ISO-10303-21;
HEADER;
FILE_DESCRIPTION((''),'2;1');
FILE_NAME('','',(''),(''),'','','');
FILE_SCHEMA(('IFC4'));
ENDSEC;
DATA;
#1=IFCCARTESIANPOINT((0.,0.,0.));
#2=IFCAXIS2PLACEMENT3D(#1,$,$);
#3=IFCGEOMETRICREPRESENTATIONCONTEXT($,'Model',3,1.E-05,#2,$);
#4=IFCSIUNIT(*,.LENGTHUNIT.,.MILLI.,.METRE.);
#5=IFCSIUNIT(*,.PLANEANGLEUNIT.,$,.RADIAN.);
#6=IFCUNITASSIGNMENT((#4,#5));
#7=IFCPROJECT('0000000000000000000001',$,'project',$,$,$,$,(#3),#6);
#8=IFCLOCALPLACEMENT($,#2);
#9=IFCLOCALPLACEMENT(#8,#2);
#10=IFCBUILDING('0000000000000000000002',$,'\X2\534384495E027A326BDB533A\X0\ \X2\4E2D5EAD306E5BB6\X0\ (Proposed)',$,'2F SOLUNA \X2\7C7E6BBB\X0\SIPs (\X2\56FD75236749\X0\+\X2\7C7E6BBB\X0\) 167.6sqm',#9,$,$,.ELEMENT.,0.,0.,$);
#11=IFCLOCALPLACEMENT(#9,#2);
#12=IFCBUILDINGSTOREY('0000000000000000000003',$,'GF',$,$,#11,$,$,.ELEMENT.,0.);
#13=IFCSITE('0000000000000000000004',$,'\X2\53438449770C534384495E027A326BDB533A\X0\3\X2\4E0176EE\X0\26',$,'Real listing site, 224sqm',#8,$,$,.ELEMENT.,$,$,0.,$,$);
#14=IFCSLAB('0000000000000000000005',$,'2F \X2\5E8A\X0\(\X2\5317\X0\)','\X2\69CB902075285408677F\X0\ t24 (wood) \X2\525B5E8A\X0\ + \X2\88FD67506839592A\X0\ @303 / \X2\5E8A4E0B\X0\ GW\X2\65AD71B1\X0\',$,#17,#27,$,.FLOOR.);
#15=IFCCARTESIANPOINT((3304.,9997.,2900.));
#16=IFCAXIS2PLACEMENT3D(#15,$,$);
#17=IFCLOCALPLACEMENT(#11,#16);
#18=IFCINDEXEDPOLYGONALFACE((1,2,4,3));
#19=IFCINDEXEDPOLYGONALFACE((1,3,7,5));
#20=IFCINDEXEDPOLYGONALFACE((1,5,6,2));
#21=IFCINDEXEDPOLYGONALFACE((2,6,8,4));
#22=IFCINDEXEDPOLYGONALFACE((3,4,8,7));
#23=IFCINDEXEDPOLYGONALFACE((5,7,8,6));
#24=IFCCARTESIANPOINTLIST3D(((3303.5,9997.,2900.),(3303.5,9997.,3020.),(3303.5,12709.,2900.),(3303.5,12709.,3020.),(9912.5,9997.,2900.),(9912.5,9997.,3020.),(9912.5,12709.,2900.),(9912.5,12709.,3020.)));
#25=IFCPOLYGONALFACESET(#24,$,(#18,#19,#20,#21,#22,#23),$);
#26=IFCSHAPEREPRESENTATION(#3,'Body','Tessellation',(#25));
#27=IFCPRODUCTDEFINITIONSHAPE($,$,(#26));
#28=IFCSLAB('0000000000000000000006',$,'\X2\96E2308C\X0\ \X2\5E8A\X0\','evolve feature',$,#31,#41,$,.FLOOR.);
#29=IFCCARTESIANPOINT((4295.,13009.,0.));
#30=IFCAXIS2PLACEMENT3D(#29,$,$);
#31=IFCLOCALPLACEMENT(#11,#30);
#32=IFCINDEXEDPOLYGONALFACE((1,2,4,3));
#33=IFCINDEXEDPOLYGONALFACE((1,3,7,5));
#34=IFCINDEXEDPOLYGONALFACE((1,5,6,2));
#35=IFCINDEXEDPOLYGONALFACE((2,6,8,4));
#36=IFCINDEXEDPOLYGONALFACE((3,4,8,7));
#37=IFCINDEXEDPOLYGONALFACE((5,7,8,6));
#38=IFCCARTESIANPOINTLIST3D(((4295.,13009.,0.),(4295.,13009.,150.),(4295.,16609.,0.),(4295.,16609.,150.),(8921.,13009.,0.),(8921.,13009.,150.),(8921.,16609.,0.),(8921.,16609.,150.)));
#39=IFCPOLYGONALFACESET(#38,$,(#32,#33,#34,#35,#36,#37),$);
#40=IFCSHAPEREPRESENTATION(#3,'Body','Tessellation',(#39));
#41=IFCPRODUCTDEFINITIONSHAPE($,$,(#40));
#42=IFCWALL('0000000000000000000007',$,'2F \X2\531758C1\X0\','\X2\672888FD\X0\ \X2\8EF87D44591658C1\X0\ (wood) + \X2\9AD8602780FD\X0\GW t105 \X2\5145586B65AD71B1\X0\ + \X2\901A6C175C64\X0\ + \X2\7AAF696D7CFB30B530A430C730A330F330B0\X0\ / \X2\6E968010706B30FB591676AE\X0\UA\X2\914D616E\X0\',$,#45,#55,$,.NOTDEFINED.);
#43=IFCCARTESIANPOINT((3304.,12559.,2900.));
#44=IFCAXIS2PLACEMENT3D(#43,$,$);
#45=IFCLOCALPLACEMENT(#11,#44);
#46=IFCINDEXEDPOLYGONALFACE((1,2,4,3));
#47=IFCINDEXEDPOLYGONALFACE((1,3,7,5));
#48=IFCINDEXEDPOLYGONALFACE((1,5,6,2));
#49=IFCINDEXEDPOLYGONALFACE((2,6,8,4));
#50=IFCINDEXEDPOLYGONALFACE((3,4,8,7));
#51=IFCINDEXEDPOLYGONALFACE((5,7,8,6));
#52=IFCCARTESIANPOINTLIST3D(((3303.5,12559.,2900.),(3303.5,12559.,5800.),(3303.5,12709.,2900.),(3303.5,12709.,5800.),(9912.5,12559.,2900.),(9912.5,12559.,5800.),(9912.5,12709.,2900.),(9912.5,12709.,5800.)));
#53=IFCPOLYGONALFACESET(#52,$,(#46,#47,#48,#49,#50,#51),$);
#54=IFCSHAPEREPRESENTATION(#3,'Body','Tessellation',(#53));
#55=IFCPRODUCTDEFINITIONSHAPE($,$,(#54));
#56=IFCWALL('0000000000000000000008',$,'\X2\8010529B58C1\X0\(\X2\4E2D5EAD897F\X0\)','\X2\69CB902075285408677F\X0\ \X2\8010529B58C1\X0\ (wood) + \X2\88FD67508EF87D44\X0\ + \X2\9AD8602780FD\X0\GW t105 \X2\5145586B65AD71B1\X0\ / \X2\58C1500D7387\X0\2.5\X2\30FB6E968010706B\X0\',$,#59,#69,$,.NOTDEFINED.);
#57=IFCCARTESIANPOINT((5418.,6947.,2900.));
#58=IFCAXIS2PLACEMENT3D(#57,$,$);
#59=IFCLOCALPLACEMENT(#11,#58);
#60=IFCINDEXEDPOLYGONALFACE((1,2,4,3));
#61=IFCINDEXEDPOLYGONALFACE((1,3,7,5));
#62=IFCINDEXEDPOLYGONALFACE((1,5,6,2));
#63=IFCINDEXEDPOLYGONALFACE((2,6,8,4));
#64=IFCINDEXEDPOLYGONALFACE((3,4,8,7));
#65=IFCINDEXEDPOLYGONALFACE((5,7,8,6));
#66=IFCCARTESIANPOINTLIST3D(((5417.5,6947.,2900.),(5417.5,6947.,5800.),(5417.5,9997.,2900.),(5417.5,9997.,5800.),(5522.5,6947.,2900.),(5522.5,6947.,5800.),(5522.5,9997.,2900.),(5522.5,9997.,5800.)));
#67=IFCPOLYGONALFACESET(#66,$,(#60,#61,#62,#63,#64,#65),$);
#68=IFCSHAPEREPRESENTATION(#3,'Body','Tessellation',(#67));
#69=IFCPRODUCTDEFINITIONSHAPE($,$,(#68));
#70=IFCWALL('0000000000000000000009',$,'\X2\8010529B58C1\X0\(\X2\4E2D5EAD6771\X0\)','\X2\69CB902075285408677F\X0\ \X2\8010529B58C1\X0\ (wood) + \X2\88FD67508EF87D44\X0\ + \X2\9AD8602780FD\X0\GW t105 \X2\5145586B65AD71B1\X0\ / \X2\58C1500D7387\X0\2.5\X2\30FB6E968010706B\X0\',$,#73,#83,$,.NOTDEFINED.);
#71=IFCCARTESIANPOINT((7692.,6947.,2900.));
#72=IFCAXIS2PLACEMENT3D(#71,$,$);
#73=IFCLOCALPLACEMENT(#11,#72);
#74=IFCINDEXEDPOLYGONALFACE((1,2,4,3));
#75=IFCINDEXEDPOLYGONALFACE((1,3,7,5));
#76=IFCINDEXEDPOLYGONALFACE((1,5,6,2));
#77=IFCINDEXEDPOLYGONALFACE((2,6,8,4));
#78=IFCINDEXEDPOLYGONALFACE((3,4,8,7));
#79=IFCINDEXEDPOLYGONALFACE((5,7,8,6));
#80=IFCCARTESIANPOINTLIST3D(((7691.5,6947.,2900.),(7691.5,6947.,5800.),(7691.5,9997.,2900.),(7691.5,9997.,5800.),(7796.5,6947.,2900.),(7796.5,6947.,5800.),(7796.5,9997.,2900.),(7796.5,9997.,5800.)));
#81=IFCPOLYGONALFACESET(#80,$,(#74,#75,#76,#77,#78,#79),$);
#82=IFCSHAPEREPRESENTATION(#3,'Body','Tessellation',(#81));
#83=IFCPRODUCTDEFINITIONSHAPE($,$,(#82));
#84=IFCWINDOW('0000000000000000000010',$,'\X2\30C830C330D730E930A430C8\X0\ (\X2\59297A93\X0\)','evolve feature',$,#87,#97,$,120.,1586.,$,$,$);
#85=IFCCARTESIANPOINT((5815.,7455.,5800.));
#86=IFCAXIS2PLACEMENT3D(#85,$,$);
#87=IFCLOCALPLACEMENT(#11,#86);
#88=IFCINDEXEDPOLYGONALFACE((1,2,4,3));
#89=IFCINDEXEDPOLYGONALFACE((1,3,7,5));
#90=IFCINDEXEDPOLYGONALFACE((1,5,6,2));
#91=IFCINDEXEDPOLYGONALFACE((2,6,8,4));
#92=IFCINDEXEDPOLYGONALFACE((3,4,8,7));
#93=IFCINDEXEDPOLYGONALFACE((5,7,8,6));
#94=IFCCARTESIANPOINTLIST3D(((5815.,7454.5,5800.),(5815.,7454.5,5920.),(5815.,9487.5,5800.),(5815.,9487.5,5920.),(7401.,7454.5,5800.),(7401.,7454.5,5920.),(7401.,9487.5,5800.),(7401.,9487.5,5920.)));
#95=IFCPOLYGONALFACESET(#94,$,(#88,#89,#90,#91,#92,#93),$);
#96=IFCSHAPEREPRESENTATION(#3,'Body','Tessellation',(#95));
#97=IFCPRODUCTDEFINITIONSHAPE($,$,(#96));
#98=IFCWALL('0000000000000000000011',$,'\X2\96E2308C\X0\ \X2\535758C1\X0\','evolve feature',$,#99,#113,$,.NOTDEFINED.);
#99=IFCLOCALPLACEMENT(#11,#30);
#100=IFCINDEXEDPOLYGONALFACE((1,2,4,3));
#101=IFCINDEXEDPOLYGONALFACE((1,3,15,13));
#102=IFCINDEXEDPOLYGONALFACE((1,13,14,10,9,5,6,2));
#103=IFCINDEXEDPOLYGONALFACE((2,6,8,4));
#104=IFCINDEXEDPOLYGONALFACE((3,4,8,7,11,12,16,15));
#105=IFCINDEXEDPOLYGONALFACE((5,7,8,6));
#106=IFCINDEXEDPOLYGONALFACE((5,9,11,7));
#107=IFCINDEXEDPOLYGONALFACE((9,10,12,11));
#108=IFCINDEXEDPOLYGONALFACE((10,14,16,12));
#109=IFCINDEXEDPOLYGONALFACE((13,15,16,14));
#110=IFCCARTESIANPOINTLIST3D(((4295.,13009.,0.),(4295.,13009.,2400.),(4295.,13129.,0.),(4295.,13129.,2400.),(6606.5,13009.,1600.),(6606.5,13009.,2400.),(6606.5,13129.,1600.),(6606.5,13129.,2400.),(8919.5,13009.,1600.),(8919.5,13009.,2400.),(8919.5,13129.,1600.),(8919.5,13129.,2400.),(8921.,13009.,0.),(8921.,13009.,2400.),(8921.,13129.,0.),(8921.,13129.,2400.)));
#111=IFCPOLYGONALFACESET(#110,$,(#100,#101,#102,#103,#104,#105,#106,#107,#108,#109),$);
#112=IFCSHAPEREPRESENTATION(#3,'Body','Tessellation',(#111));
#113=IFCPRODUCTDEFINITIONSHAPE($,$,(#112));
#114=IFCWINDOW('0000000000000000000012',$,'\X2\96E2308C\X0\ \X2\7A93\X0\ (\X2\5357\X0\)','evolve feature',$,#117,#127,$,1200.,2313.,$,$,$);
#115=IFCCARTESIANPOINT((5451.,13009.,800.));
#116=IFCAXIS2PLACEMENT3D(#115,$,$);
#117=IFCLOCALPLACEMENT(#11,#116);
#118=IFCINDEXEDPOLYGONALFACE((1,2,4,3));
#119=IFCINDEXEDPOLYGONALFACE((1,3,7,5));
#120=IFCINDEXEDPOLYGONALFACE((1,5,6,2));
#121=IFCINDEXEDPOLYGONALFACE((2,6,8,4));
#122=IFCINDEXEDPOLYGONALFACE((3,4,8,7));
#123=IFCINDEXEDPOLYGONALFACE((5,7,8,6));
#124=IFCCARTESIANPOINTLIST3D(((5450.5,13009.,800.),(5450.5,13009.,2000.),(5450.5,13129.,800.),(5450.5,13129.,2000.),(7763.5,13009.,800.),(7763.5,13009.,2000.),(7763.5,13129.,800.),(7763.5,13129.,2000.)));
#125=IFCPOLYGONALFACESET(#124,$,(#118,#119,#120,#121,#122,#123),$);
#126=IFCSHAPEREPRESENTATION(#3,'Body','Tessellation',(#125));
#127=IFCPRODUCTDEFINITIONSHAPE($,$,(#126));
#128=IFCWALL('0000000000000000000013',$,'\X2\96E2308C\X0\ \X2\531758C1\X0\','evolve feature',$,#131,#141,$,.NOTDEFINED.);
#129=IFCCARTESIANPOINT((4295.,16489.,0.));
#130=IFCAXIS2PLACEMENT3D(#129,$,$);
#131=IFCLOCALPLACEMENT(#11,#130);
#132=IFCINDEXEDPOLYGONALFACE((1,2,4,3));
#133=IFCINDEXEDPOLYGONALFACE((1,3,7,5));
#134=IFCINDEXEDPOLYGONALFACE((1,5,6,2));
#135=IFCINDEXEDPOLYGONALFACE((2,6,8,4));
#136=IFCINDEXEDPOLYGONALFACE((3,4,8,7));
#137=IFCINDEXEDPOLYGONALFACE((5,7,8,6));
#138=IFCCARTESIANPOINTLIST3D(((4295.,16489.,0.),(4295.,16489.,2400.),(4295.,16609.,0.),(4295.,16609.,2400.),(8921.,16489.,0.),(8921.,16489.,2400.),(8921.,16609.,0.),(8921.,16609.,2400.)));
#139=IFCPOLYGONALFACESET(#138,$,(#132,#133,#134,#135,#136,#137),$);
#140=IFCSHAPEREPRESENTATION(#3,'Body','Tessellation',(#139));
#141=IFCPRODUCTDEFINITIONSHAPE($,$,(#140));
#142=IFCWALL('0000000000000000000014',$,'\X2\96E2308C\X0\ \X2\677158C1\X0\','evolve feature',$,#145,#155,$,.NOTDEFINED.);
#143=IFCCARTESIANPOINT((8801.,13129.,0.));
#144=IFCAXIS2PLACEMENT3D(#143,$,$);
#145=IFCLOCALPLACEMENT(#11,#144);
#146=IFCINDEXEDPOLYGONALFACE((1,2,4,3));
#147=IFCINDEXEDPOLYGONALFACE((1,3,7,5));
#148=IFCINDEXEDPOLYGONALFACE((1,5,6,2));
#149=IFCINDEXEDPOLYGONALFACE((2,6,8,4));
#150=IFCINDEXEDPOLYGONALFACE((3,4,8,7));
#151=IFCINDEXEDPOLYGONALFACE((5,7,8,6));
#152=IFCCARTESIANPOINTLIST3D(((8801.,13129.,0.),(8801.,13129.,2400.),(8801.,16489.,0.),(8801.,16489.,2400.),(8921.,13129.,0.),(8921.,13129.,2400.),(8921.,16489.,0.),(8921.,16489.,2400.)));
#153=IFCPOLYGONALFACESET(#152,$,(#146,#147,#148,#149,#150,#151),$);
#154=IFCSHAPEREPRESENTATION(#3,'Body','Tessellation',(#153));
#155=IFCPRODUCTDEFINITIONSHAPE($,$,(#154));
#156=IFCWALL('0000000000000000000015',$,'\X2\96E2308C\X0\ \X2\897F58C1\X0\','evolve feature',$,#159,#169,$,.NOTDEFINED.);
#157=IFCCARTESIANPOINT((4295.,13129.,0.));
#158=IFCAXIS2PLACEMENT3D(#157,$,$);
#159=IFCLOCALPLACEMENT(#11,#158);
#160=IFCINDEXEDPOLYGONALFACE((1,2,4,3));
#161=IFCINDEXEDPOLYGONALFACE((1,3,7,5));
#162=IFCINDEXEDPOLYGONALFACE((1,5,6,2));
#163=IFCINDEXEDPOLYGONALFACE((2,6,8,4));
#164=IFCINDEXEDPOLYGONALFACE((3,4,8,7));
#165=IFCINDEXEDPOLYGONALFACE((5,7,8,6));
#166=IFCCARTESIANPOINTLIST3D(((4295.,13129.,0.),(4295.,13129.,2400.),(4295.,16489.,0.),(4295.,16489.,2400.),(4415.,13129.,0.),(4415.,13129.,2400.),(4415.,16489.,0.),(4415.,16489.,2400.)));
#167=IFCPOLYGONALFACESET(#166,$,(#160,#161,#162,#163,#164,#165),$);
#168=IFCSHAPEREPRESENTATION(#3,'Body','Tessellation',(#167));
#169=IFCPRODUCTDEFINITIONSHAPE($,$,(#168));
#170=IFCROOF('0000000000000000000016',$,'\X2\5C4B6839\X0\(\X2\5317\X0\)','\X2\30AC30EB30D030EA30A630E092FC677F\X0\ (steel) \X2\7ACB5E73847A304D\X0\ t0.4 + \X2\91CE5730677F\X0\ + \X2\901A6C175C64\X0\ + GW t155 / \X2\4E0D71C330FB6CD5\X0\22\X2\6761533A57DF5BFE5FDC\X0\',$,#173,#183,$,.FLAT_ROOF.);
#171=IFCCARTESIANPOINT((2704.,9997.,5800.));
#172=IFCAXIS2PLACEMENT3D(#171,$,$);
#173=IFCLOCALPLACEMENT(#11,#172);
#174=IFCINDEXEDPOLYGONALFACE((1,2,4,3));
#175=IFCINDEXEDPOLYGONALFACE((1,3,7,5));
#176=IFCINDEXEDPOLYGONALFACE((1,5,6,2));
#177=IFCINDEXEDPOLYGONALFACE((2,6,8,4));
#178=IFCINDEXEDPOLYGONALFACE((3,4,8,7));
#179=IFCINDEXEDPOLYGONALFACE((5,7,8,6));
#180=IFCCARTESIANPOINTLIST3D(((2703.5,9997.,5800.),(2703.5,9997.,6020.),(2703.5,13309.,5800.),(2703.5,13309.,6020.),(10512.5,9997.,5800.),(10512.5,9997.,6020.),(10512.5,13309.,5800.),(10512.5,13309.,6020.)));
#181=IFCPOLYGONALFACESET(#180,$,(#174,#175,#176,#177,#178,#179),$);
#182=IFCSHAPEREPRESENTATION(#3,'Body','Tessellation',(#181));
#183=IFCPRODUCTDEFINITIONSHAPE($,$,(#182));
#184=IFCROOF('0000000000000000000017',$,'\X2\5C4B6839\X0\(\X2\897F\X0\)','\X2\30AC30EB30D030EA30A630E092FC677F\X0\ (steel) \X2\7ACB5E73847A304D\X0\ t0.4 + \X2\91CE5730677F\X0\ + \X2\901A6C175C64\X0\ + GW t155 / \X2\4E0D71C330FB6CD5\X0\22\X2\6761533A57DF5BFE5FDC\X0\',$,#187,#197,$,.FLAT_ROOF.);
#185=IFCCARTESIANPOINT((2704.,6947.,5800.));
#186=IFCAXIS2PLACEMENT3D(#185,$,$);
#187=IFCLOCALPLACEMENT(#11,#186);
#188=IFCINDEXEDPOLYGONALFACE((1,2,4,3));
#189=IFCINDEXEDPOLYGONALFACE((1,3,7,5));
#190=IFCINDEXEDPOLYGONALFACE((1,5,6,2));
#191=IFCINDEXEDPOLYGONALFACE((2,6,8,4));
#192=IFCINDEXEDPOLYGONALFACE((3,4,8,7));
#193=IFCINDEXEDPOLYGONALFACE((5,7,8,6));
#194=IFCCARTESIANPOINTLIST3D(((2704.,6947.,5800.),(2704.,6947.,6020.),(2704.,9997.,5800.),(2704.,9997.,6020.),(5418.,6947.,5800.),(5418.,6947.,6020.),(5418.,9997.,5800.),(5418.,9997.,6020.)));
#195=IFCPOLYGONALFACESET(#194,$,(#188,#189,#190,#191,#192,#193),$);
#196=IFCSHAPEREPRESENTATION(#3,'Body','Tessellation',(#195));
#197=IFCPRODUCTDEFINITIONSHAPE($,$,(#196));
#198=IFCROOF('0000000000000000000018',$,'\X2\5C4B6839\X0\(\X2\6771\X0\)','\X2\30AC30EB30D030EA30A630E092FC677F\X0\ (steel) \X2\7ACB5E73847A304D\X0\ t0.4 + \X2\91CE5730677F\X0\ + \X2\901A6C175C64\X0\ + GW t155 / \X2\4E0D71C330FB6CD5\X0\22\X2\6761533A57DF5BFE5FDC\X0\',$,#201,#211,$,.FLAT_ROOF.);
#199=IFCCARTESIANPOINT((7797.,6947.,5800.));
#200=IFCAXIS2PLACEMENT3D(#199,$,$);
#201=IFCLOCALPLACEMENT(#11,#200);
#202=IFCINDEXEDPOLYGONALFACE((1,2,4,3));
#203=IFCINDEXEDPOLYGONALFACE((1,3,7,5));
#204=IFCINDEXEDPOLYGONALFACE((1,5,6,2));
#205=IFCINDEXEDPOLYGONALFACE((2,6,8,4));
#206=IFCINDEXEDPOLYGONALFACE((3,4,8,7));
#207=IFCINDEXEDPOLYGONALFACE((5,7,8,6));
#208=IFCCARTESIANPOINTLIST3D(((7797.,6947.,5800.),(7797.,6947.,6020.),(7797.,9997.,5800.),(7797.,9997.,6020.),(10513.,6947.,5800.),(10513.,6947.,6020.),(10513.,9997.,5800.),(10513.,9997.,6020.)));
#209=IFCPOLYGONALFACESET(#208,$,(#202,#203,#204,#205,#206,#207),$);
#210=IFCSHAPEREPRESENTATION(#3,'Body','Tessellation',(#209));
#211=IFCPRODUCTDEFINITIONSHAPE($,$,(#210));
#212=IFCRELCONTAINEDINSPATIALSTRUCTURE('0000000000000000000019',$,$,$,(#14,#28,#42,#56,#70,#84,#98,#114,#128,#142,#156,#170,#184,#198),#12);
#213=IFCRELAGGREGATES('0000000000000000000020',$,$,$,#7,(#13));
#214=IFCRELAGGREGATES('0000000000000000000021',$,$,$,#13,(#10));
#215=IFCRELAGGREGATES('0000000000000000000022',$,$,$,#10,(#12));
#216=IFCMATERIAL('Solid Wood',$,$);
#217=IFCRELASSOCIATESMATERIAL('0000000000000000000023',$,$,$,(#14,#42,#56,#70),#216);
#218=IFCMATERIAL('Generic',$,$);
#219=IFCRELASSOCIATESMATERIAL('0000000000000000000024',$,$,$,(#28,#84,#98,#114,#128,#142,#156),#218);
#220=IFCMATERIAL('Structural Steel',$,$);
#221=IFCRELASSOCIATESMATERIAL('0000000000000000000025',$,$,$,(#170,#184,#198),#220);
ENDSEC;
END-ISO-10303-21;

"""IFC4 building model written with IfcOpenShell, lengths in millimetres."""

from ifc_helpers import new_model, si_unit, frame, frame_2d, origin, place, context, project, spatial, rectangle, extrude, material, element, fill, save


model = new_model("IFC4")

# Units and contexts
model_context = context("Model", 3, precision=1e-05, world=origin())
ifc_project = project(units=[si_unit("LENGTHUNIT", "METRE", prefix="MILLI"), si_unit("PLANEANGLEUNIT", "RADIAN")], contexts=[model_context])

# Site, building, storey
site_placement = place(None, origin())
site = spatial("IfcSite", under=ifc_project, at=site_placement, Name="千葉県千葉市稲毛区3丁目26", ObjectType="Real listing site, 224sqm", CompositionType="ELEMENT", RefElevation=0.0)
building_placement = place(site_placement, origin())
building = spatial("IfcBuilding", under=site, at=building_placement, Name="千葉市稲毛区 中庭の家 (Proposed)", ObjectType="2F SOLUNA 籾殻SIPs (国産杉+籾殻) 167.6sqm", CompositionType="ELEMENT", ElevationOfRefHeight=0.0, ElevationOfTerrain=0.0)
storey_placement = place(building_placement, origin())
storey = spatial("IfcBuildingStorey", under=building, at=storey_placement, Name="GF", CompositionType="ELEMENT", Elevation=0.0)

# Slabs
ifc_material_1 = material(Name="Solid Wood")
slab_1_placement = place(storey_placement, frame((3304.0, 9997.0, 2900.0)))
element("IfcSlab", 1, at=slab_1_placement, inside=storey, material=ifc_material_1, Name="2F 床(北)", Description="構造用合板 t24 (wood) 剛床 + 製材根太 @303 / 床下 GW断熱", PredefinedType="FLOOR", context=model_context, shape_type="SweptSolid", body=[
    extrude(rectangle(XDim=6609.0, YDim=2712.0, at=frame_2d((3304.0, 1356.0))), frame((3304.0, 9997.0, 2900.0)), (0.0, 0.0, 1.0), 120.0),
])
ifc_material_2 = material(Name="Generic")
slab_2_placement = place(storey_placement, frame((4295.0, 13009.0, 0.0)))
element("IfcSlab", 2, at=slab_2_placement, inside=storey, material=ifc_material_2, Name="離れ 床", Description="evolve feature", PredefinedType="FLOOR", context=model_context, shape_type="SweptSolid", body=[
    extrude(rectangle(XDim=4626.0, YDim=3600.0, at=frame_2d((2313.0, 1800.0))), frame((4295.0, 13009.0, 0.0)), (0.0, 0.0, 1.0), 150.0),
])

# Wall
wall_1_placement = place(storey_placement, frame((3304.0, 12559.0, 2900.0)))
element("IfcWall", 3, at=wall_1_placement, inside=storey, material=ifc_material_1, Name="2F 北壁", Description="木製 軸組外壁 (wood) + 高性能GW t105 充填断熱 + 通気層 + 窯業系サイディング / 準耐火・外皮UA配慮", PredefinedType="NOTDEFINED", context=model_context, shape_type="SweptSolid", body=[
    extrude(rectangle(XDim=6609.0, YDim=150.0, at=frame_2d((3304.0, 75.0))), frame((3304.0, 12559.0, 2900.0)), (0.0, 0.0, 1.0), 2900.0),
])

# Walls
wall_2_placement = place(storey_placement, frame((5418.0, 6947.0, 2900.0)))
element("IfcWall", 4, at=wall_2_placement, inside=storey, material=ifc_material_1, Name="耐力壁(中庭西)", Description="構造用合板 耐力壁 (wood) + 製材軸組 + 高性能GW t105 充填断熱 / 壁倍率2.5・準耐火", PredefinedType="NOTDEFINED", context=model_context, shape_type="SweptSolid", body=[
    extrude(rectangle(XDim=105.0, YDim=3050.0, at=frame_2d((52.0, 1525.0))), frame((5418.0, 6947.0, 2900.0)), (0.0, 0.0, 1.0), 2900.0),
])
wall_3_placement = place(storey_placement, frame((7692.0, 6947.0, 2900.0)))
element("IfcWall", 5, at=wall_3_placement, inside=storey, material=ifc_material_1, Name="耐力壁(中庭東)", Description="構造用合板 耐力壁 (wood) + 製材軸組 + 高性能GW t105 充填断熱 / 壁倍率2.5・準耐火", PredefinedType="NOTDEFINED", context=model_context, shape_type="SweptSolid", body=[
    extrude(rectangle(XDim=105.0, YDim=3050.0, at=frame_2d((52.0, 1525.0))), frame((7692.0, 6947.0, 2900.0)), (0.0, 0.0, 1.0), 2900.0),
])

# Window
window_1_placement = place(storey_placement, frame((5815.0, 7455.0, 5800.0)))
element("IfcWindow", 6, at=window_1_placement, inside=storey, material=ifc_material_2, Name="トップライト (天窓)", Description="evolve feature", OverallHeight=120.0, OverallWidth=1586.0, context=model_context, shape_type="SweptSolid", body=[
    extrude(rectangle(XDim=1586.0, YDim=2033.0, at=frame_2d((793.0, 1016.0))), frame((5815.0, 7455.0, 5800.0)), (0.0, 0.0, 1.0), 120.0),
])

# Wall, opening, window
wall_4_placement = place(storey_placement, frame((4295.0, 13009.0, 0.0)))
wall_4 = element("IfcWall", 7, at=wall_4_placement, inside=storey, material=ifc_material_2, Name="離れ 南壁", Description="evolve feature", PredefinedType="NOTDEFINED", context=model_context, shape_type="SweptSolid", body=[
    extrude(rectangle(XDim=4626.0, YDim=120.0, at=frame_2d((2313.0, 60.0))), frame((4295.0, 13009.0, 0.0)), (0.0, 0.0, 1.0), 2400.0),
])
opening_1_placement = place(storey_placement, frame((5451.0, 13009.0, 800.0)))
opening_1 = element("IfcOpeningElement", 8, at=opening_1_placement, cuts=wall_4, PredefinedType="NOTDEFINED", context=model_context, shape_type="SweptSolid", body=[
    extrude(rectangle(XDim=2313.0, YDim=120.0, at=frame_2d((1156.0, 60.0))), frame((5451.0, 13009.0, 800.0)), (0.0, 0.0, 1.0), 1200.0),
])
window_2_placement = place(storey_placement, frame((5451.0, 13009.0, 800.0)))
window_2 = element("IfcWindow", 9, at=window_2_placement, inside=storey, material=ifc_material_2, Name="離れ 窓 (南)", Description="evolve feature", OverallHeight=1200.0, OverallWidth=2313.0, context=model_context, shape_type="SweptSolid", body=[
    extrude(rectangle(XDim=2313.0, YDim=120.0, at=frame_2d((1156.0, 60.0))), frame((5451.0, 13009.0, 800.0)), (0.0, 0.0, 1.0), 1200.0),
])
fill(opening_1, window_2)

# Walls
wall_5_placement = place(storey_placement, frame((4295.0, 16489.0, 0.0)))
element("IfcWall", 10, at=wall_5_placement, inside=storey, material=ifc_material_2, Name="離れ 北壁", Description="evolve feature", PredefinedType="NOTDEFINED", context=model_context, shape_type="SweptSolid", body=[
    extrude(rectangle(XDim=4626.0, YDim=120.0, at=frame_2d((2313.0, 60.0))), frame((4295.0, 16489.0, 0.0)), (0.0, 0.0, 1.0), 2400.0),
])
wall_6_placement = place(storey_placement, frame((8801.0, 13129.0, 0.0)))
element("IfcWall", 11, at=wall_6_placement, inside=storey, material=ifc_material_2, Name="離れ 東壁", Description="evolve feature", PredefinedType="NOTDEFINED", context=model_context, shape_type="SweptSolid", body=[
    extrude(rectangle(XDim=120.0, YDim=3360.0, at=frame_2d((60.0, 1680.0))), frame((8801.0, 13129.0, 0.0)), (0.0, 0.0, 1.0), 2400.0),
])
wall_7_placement = place(storey_placement, frame((4295.0, 13129.0, 0.0)))
element("IfcWall", 12, at=wall_7_placement, inside=storey, material=ifc_material_2, Name="離れ 西壁", Description="evolve feature", PredefinedType="NOTDEFINED", context=model_context, shape_type="SweptSolid", body=[
    extrude(rectangle(XDim=120.0, YDim=3360.0, at=frame_2d((60.0, 1680.0))), frame((4295.0, 13129.0, 0.0)), (0.0, 0.0, 1.0), 2400.0),
])

# Roofs
ifc_material_3 = material(Name="Structural Steel")
for number, where, name in (
    (13, (2704.0, 9997.0, 5800.0), "屋根(北)"),
):
    element("IfcRoof", number, at=place(storey_placement, frame(where)), inside=storey, material=ifc_material_3, Name=name, Description="ガルバリウム鋼板 (steel) 立平葺き t0.4 + 野地板 + 通気層 + GW t155 / 不燃・法22条区域対応", PredefinedType="FLAT_ROOF", context=model_context, shape_type="SweptSolid", body=[
        extrude(rectangle(XDim=7809.0, YDim=3312.0, at=frame_2d((3904.0, 1656.0))), frame((2704.0, 9997.0, 5800.0)), (0.0, 0.0, 1.0), 220.0),
    ])
roof_1_placement = place(storey_placement, frame((2704.0, 6947.0, 5800.0)))
element("IfcRoof", 14, at=roof_1_placement, inside=storey, material=ifc_material_3, Name="屋根(西)", Description="ガルバリウム鋼板 (steel) 立平葺き t0.4 + 野地板 + 通気層 + GW t155 / 不燃・法22条区域対応", PredefinedType="FLAT_ROOF", context=model_context, shape_type="SweptSolid", body=[
    extrude(rectangle(XDim=2714.0, YDim=3050.0, at=frame_2d((1357.0, 1525.0))), frame((2704.0, 6947.0, 5800.0)), (0.0, 0.0, 1.0), 220.0),
])
roof_2_placement = place(storey_placement, frame((7797.0, 6947.0, 5800.0)))
element("IfcRoof", 15, at=roof_2_placement, inside=storey, material=ifc_material_3, Name="屋根(東)", Description="ガルバリウム鋼板 (steel) 立平葺き t0.4 + 野地板 + 通気層 + GW t155 / 不燃・法22条区域対応", PredefinedType="FLAT_ROOF", context=model_context, shape_type="SweptSolid", body=[
    extrude(rectangle(XDim=2716.0, YDim=3050.0, at=frame_2d((1358.0, 1525.0))), frame((7797.0, 6947.0, 5800.0)), (0.0, 0.0, 1.0), 220.0),
])

save(model, "model.ifc")
